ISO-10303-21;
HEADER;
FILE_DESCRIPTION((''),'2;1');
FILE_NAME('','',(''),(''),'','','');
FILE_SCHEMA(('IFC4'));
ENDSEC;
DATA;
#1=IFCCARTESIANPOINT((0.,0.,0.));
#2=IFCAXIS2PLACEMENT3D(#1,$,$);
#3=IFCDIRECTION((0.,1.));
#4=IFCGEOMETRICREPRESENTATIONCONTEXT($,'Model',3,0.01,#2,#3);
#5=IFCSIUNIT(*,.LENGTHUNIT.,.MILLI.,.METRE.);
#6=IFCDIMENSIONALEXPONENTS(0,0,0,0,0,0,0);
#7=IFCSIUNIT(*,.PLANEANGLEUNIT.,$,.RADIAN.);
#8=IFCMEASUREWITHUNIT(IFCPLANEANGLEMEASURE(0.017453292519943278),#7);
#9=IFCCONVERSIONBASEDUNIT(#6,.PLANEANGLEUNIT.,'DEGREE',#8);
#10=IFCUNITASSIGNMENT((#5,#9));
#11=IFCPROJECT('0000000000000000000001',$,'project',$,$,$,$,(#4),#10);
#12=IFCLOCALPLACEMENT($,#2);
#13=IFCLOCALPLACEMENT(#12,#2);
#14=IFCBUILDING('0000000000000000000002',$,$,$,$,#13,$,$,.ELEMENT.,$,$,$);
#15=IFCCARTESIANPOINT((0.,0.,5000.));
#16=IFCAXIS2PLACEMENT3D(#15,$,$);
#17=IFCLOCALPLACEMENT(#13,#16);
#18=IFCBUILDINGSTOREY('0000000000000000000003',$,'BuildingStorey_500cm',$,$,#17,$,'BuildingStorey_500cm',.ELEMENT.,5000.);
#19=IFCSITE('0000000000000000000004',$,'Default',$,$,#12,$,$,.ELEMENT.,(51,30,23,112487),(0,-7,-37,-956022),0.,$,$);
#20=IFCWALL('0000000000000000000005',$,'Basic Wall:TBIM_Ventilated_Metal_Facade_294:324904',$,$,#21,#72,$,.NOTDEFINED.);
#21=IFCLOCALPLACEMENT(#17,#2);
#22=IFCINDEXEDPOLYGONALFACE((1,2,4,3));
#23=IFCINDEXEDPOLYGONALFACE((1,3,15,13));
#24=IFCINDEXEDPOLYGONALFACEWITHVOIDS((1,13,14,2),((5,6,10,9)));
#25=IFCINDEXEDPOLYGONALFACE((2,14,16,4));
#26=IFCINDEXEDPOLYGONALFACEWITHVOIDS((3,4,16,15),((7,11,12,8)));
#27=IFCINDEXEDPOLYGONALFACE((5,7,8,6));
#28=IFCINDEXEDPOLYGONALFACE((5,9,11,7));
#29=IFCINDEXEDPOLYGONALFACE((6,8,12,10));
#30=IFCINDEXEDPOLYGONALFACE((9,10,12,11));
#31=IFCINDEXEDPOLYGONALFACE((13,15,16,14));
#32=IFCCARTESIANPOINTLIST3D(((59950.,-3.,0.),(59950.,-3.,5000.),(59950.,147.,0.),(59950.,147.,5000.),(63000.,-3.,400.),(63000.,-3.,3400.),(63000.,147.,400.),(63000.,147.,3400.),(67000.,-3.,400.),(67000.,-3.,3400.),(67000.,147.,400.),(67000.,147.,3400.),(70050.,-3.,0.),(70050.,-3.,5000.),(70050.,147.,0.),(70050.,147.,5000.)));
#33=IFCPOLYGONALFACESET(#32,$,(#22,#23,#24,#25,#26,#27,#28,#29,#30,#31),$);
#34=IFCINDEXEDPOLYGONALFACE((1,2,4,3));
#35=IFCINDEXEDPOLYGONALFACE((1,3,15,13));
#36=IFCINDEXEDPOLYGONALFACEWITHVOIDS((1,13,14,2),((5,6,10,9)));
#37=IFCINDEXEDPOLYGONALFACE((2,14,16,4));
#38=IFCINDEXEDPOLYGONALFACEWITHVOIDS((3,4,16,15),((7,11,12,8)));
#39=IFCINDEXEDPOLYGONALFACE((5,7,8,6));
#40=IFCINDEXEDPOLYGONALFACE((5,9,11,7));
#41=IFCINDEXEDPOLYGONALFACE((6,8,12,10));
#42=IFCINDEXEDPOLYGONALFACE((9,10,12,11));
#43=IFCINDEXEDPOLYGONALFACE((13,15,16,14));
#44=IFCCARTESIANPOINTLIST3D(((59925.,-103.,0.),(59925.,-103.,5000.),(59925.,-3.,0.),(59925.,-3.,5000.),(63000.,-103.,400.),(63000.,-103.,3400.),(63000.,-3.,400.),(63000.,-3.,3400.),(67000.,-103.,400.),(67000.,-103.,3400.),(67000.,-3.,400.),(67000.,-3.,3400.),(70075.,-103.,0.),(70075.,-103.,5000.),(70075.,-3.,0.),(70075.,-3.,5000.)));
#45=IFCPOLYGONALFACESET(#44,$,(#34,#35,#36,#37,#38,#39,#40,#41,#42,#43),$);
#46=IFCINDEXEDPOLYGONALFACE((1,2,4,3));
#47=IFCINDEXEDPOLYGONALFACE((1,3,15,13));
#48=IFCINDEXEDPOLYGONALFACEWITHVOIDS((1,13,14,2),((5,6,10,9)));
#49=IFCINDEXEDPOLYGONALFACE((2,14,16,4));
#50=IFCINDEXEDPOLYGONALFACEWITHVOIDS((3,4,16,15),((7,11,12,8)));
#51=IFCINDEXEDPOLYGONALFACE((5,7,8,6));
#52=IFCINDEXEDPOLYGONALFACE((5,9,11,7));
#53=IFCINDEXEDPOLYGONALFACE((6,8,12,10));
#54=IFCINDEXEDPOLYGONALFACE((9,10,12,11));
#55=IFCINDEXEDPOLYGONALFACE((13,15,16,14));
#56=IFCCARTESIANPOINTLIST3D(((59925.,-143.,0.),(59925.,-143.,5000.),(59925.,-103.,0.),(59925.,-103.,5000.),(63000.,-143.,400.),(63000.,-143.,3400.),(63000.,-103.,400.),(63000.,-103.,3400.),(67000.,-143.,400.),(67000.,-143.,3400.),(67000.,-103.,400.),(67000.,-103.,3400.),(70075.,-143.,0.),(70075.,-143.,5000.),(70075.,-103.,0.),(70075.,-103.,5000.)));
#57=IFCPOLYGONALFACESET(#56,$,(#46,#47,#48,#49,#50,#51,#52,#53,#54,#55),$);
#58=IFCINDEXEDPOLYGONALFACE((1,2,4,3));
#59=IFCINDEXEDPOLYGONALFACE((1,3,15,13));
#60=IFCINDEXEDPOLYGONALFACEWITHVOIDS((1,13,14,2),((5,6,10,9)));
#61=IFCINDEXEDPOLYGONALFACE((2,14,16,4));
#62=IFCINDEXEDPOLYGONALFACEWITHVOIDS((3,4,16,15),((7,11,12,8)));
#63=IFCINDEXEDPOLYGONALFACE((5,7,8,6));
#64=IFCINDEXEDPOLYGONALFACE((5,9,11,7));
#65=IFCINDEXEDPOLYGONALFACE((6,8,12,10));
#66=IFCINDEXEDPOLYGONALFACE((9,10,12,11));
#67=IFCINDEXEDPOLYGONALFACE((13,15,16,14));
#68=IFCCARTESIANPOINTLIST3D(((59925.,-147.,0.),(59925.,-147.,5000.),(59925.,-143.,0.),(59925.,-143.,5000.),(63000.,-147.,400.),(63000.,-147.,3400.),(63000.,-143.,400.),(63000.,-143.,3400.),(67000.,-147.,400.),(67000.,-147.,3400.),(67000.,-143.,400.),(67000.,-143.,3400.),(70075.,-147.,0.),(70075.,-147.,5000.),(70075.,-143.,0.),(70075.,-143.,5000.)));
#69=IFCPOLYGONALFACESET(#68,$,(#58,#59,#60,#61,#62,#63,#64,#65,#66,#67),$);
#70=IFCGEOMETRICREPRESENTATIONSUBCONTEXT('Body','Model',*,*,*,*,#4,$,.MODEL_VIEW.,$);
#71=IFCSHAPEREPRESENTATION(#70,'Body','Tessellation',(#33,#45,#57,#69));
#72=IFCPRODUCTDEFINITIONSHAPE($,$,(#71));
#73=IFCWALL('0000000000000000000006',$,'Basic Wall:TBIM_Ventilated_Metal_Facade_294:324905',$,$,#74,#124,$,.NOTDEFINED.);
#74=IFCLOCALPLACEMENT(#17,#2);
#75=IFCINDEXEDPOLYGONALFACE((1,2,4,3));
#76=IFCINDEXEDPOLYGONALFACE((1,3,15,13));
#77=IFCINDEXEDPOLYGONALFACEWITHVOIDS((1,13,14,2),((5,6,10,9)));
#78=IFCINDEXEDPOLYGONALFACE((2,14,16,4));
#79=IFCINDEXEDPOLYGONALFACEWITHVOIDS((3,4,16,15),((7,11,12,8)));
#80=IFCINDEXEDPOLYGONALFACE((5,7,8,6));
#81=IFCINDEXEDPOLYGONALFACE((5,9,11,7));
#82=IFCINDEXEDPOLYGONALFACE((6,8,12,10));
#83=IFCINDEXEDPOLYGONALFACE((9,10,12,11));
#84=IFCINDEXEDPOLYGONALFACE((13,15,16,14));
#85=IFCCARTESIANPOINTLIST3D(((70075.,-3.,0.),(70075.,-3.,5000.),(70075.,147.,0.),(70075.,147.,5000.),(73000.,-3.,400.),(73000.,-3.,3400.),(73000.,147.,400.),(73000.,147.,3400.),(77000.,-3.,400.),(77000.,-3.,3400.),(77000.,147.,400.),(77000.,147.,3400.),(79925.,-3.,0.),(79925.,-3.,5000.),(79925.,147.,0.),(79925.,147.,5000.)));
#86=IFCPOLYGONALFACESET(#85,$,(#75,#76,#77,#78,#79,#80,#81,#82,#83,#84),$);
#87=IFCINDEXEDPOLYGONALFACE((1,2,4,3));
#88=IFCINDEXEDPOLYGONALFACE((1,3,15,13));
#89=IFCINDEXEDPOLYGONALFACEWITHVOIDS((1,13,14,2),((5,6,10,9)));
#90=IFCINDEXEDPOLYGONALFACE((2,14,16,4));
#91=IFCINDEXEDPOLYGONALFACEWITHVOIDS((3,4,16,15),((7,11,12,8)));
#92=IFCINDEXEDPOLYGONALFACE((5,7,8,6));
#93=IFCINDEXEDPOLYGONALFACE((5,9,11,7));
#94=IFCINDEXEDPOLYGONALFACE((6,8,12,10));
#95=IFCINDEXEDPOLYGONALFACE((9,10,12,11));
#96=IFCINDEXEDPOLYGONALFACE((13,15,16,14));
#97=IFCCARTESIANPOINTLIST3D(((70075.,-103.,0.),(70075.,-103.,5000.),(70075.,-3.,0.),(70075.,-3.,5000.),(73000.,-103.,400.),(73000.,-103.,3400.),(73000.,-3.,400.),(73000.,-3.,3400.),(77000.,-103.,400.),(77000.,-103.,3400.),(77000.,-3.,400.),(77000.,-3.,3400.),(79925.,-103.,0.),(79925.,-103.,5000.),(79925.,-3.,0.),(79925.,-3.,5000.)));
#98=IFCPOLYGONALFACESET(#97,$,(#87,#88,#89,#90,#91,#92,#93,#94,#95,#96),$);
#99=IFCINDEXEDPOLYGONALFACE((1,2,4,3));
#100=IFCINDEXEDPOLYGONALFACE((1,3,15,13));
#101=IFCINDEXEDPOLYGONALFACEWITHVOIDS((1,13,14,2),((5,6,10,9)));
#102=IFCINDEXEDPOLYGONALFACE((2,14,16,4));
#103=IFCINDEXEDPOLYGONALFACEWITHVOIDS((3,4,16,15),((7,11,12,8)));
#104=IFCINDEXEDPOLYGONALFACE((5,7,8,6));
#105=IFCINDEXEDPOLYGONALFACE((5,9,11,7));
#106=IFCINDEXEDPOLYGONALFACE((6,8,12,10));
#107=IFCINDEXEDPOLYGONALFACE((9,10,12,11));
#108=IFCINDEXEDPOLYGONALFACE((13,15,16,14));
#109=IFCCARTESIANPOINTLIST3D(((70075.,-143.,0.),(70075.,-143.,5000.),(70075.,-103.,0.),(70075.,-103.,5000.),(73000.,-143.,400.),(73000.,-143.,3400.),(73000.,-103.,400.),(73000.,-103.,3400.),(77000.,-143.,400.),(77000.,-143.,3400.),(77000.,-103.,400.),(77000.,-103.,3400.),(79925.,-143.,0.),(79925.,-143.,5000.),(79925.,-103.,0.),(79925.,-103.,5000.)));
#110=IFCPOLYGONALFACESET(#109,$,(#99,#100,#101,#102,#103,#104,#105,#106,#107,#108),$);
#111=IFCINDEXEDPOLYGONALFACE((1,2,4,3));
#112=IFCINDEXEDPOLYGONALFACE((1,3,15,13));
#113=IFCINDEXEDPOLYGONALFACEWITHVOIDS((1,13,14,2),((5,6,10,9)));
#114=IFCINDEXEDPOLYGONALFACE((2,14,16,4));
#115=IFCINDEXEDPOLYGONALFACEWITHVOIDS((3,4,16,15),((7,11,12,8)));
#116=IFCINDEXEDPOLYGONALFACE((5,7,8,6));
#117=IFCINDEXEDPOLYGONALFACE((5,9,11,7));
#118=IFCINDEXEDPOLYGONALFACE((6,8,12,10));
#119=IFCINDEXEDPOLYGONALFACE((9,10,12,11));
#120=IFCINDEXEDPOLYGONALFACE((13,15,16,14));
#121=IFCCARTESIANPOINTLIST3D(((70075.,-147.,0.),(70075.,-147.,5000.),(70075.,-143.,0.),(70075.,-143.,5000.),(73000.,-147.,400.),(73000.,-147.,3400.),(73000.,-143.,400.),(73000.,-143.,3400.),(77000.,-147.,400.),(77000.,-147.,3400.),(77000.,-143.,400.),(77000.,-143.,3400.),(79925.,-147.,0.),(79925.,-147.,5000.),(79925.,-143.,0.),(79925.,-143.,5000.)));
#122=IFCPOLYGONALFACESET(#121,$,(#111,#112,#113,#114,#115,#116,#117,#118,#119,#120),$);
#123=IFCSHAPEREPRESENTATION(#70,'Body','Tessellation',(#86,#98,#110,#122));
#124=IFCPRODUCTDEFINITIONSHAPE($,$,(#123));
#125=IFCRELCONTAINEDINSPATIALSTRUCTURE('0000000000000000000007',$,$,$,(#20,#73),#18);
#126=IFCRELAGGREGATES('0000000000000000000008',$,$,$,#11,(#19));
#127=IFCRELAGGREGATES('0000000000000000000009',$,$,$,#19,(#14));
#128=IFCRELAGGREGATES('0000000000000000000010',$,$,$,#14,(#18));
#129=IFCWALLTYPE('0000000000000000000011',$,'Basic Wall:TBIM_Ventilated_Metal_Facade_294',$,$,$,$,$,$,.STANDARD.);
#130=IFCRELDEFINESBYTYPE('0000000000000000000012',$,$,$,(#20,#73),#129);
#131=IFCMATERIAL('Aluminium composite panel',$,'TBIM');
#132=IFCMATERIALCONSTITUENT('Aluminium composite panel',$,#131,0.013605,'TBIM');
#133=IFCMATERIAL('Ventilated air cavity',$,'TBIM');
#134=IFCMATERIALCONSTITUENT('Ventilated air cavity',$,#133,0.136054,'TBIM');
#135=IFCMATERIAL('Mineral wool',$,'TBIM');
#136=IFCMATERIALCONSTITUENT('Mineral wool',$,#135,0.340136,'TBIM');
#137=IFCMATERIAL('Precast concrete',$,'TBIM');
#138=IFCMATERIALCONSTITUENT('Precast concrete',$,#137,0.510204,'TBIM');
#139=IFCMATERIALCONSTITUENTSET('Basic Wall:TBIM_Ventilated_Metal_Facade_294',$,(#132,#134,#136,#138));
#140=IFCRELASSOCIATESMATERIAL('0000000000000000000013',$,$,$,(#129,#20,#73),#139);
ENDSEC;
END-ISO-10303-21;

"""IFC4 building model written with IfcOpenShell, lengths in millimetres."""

from ifc_helpers import new_model, entity, si_unit, converted_unit, direction, frame, origin, place, context, subcontext, project, spatial, indexed_curve, outline, extrude, material, constituent, constituent_set, type_object, element, save


model = new_model("IFC4")

# Units and contexts
model_context = context("Model", 3, precision=0.01, world=origin(), true_north=direction((0.0, 1.0)))
body_context = subcontext(model_context, "Body", "Model", "MODEL_VIEW")
ifc_project = project(units=[si_unit("LENGTHUNIT", "METRE", prefix="MILLI"), converted_unit("PLANEANGLEUNIT", "DEGREE", entity("IfcPlaneAngleMeasure", 0.017453292519943278), si_unit("PLANEANGLEUNIT", "RADIAN"), dimensions=[0, 0, 0, 0, 0, 0, 0])], contexts=[model_context])

# Site, building, storey
site_placement = place(None, origin())
site = spatial("IfcSite", under=ifc_project, at=site_placement, Name="Default", CompositionType="ELEMENT", RefLatitude=(51, 30, 23, 112487), RefLongitude=(0, -7, -37, -956022), RefElevation=0.0)
building_placement = place(site_placement, origin())
building = spatial("IfcBuilding", under=site, at=building_placement, CompositionType="ELEMENT")
storey_placement = place(building_placement, frame((0.0, 0.0, 5000.0)))
storey = spatial("IfcBuildingStorey", under=building, at=storey_placement, Name="BuildingStorey_500cm", LongName="BuildingStorey_500cm", CompositionType="ELEMENT", Elevation=5000.0)

# Walls, openings
ifc_material_1 = material(Name="Aluminium composite panel", Category="TBIM")
ifc_constituent_1 = constituent(ifc_material_1, Name="Aluminium composite panel", Category="TBIM", fraction=0.013605)
ifc_material_2 = material(Name="Ventilated air cavity", Category="TBIM")
ifc_constituent_2 = constituent(ifc_material_2, Name="Ventilated air cavity", Category="TBIM", fraction=0.136054)
ifc_material_3 = material(Name="Mineral wool", Category="TBIM")
ifc_constituent_3 = constituent(ifc_material_3, Name="Mineral wool", Category="TBIM", fraction=0.340136)
ifc_material_4 = material(Name="Precast concrete", Category="TBIM")
ifc_constituent_4 = constituent(ifc_material_4, Name="Precast concrete", Category="TBIM", fraction=0.510204)
ifc_constituent_set_1 = constituent_set(constituents=[ifc_constituent_1, ifc_constituent_2, ifc_constituent_3, ifc_constituent_4], Name="Basic Wall:TBIM_Ventilated_Metal_Facade_294")
wall_type_1 = type_object("IfcWallType", Name="Basic Wall:TBIM_Ventilated_Metal_Facade_294", PredefinedType="STANDARD", material=ifc_constituent_set_1)
wall_1_placement = place(storey_placement, frame((59925.0, 0.0, 0.0)))
wall_1 = element("IfcWall", 1, at=wall_1_placement, inside=storey, type_object=wall_type_1, material=ifc_constituent_set_1, Name="Basic Wall:TBIM_Ventilated_Metal_Facade_294:324904", PredefinedType="NOTDEFINED", context=body_context, shape_type="SweptSolid", body=[
    extrude(outline(indexed_curve([(-2500.0, -5050.0), (2500.0, -5050.0), (2500.0, 5050.0), (-2500.0, 5050.0), (-2500.0, -5050.0)], self_intersect=False), holes=[indexed_curve([(-2100.0, -2000.0), (-2100.0, 2000.0), (900.0, 2000.0), (900.0, -2000.0), (-2100.0, -2000.0)], self_intersect=False)]), frame((5075.0, -3.0, 2500.0), z_axis=(0.0, 1.0, 0.0), x_axis=(0.0, 0.0, 1.0)), (0.0, 0.0, 1.0), 150.0),
    extrude(outline(indexed_curve([(-2500.0, -5075.0), (2500.0, -5075.0), (2500.0, 5075.0), (-2500.0, 5075.0), (-2500.0, -5075.0)], self_intersect=False), holes=[indexed_curve([(-2100.0, -2000.0), (-2100.0, 2000.0), (900.0, 2000.0), (900.0, -2000.0), (-2100.0, -2000.0)], self_intersect=False)]), frame((5075.0, -103.0, 2500.0), z_axis=(0.0, 1.0, 0.0), x_axis=(0.0, 0.0, 1.0)), (0.0, 0.0, 1.0), 100.0),
    extrude(outline(indexed_curve([(-2500.0, -5075.0), (2500.0, -5075.0), (2500.0, 5075.0), (-2500.0, 5075.0), (-2500.0, -5075.0)], self_intersect=False), holes=[indexed_curve([(-2100.0, -2000.0), (-2100.0, 2000.0), (900.0, 2000.0), (900.0, -2000.0), (-2100.0, -2000.0)], self_intersect=False)]), frame((5075.0, -143.0, 2500.0), z_axis=(0.0, 1.0, 0.0), x_axis=(0.0, 0.0, 1.0)), (0.0, 0.0, 1.0), 40.0),
    extrude(outline(indexed_curve([(-2500.0, -5075.0), (2500.0, -5075.0), (2500.0, 5075.0), (-2500.0, 5075.0), (-2500.0, -5075.0)], self_intersect=False), holes=[indexed_curve([(900.0, -2000.0), (-2100.0, -2000.0), (-2100.0, 2000.0), (900.0, 2000.0), (900.0, -2000.0)], self_intersect=False)]), frame((5075.0, -147.0, 2500.0), z_axis=(0.0, 1.0, 0.0), x_axis=(0.0, 0.0, 1.0)), (0.0, 0.0, 1.0), 4.0),
])
opening_1_placement = place(wall_1_placement, frame((3075.0, -147.0, 400.0)))
element("IfcOpeningElement", 2, at=opening_1_placement, cuts=wall_1, PredefinedType="OPENING", context=body_context, shape_type="SweptSolid", body=[
    extrude(outline(indexed_curve([(3000.0, 0.0), (3000.0, 4000.0), (0.0, 4000.0), (0.0, 0.0), (3000.0, 0.0)], self_intersect=False)), frame((0.0, 0.0, 0.0), z_axis=(0.0, 1.0, 0.0), x_axis=(0.0, 0.0, 1.0)), (0.0, 0.0, 1.0), 294.0),
])
wall_2_placement = place(storey_placement, frame((70075.0, 0.0, 0.0)))
wall_2 = element("IfcWall", 3, at=wall_2_placement, inside=storey, type_object=wall_type_1, material=ifc_constituent_set_1, Name="Basic Wall:TBIM_Ventilated_Metal_Facade_294:324905", PredefinedType="NOTDEFINED", context=body_context, shape_type="SweptSolid", body=[
    extrude(outline(indexed_curve([(-2500.0, -4925.0), (2500.0, -4925.0), (2500.0, 4925.0), (-2500.0, 4925.0), (-2500.0, -4925.0)], self_intersect=False), holes=[indexed_curve([(-2100.0, -2000.0), (-2100.0, 2000.0), (900.0, 2000.0), (900.0, -2000.0), (-2100.0, -2000.0)], self_intersect=False)]), frame((4925.0, -3.0, 2500.0), z_axis=(0.0, 1.0, 0.0), x_axis=(0.0, 0.0, 1.0)), (0.0, 0.0, 1.0), 150.0),
    extrude(outline(indexed_curve([(-2500.0, -4925.0), (2500.0, -4925.0), (2500.0, 4925.0), (-2500.0, 4925.0), (-2500.0, -4925.0)], self_intersect=False), holes=[indexed_curve([(-2100.0, -2000.0), (-2100.0, 2000.0), (900.0, 2000.0), (900.0, -2000.0), (-2100.0, -2000.0)], self_intersect=False)]), frame((4925.0, -103.0, 2500.0), z_axis=(0.0, 1.0, 0.0), x_axis=(0.0, 0.0, 1.0)), (0.0, 0.0, 1.0), 100.0),
    extrude(outline(indexed_curve([(-2500.0, -4925.0), (2500.0, -4925.0), (2500.0, 4925.0), (-2500.0, 4925.0), (-2500.0, -4925.0)], self_intersect=False), holes=[indexed_curve([(-2100.0, -2000.0), (-2100.0, 2000.0), (900.0, 2000.0), (900.0, -2000.0), (-2100.0, -2000.0)], self_intersect=False)]), frame((4925.0, -143.0, 2500.0), z_axis=(0.0, 1.0, 0.0), x_axis=(0.0, 0.0, 1.0)), (0.0, 0.0, 1.0), 40.0),
    extrude(outline(indexed_curve([(-2500.0, -4925.0), (2500.0, -4925.0), (2500.0, 4925.0), (-2500.0, 4925.0), (-2500.0, -4925.0)], self_intersect=False), holes=[indexed_curve([(900.0, -2000.0), (-2100.0, -2000.0), (-2100.0, 2000.0), (900.0, 2000.0), (900.0, -2000.0)], self_intersect=False)]), frame((4925.0, -147.0, 2500.0), z_axis=(0.0, 1.0, 0.0), x_axis=(0.0, 0.0, 1.0)), (0.0, 0.0, 1.0), 4.0),
])
opening_2_placement = place(wall_2_placement, frame((2925.0, -147.0, 400.0)))
element("IfcOpeningElement", 4, at=opening_2_placement, cuts=wall_2, PredefinedType="OPENING", context=body_context, shape_type="SweptSolid", body=[
    extrude(outline(indexed_curve([(3000.0, 0.0), (3000.0, 4000.0), (0.0, 4000.0), (0.0, 0.0), (3000.0, 0.0)], self_intersect=False)), frame((0.0, 0.0, 0.0), z_axis=(0.0, 1.0, 0.0), x_axis=(0.0, 0.0, 1.0)), (0.0, 0.0, 1.0), 294.0),
])

save(model, "model.ifc")
